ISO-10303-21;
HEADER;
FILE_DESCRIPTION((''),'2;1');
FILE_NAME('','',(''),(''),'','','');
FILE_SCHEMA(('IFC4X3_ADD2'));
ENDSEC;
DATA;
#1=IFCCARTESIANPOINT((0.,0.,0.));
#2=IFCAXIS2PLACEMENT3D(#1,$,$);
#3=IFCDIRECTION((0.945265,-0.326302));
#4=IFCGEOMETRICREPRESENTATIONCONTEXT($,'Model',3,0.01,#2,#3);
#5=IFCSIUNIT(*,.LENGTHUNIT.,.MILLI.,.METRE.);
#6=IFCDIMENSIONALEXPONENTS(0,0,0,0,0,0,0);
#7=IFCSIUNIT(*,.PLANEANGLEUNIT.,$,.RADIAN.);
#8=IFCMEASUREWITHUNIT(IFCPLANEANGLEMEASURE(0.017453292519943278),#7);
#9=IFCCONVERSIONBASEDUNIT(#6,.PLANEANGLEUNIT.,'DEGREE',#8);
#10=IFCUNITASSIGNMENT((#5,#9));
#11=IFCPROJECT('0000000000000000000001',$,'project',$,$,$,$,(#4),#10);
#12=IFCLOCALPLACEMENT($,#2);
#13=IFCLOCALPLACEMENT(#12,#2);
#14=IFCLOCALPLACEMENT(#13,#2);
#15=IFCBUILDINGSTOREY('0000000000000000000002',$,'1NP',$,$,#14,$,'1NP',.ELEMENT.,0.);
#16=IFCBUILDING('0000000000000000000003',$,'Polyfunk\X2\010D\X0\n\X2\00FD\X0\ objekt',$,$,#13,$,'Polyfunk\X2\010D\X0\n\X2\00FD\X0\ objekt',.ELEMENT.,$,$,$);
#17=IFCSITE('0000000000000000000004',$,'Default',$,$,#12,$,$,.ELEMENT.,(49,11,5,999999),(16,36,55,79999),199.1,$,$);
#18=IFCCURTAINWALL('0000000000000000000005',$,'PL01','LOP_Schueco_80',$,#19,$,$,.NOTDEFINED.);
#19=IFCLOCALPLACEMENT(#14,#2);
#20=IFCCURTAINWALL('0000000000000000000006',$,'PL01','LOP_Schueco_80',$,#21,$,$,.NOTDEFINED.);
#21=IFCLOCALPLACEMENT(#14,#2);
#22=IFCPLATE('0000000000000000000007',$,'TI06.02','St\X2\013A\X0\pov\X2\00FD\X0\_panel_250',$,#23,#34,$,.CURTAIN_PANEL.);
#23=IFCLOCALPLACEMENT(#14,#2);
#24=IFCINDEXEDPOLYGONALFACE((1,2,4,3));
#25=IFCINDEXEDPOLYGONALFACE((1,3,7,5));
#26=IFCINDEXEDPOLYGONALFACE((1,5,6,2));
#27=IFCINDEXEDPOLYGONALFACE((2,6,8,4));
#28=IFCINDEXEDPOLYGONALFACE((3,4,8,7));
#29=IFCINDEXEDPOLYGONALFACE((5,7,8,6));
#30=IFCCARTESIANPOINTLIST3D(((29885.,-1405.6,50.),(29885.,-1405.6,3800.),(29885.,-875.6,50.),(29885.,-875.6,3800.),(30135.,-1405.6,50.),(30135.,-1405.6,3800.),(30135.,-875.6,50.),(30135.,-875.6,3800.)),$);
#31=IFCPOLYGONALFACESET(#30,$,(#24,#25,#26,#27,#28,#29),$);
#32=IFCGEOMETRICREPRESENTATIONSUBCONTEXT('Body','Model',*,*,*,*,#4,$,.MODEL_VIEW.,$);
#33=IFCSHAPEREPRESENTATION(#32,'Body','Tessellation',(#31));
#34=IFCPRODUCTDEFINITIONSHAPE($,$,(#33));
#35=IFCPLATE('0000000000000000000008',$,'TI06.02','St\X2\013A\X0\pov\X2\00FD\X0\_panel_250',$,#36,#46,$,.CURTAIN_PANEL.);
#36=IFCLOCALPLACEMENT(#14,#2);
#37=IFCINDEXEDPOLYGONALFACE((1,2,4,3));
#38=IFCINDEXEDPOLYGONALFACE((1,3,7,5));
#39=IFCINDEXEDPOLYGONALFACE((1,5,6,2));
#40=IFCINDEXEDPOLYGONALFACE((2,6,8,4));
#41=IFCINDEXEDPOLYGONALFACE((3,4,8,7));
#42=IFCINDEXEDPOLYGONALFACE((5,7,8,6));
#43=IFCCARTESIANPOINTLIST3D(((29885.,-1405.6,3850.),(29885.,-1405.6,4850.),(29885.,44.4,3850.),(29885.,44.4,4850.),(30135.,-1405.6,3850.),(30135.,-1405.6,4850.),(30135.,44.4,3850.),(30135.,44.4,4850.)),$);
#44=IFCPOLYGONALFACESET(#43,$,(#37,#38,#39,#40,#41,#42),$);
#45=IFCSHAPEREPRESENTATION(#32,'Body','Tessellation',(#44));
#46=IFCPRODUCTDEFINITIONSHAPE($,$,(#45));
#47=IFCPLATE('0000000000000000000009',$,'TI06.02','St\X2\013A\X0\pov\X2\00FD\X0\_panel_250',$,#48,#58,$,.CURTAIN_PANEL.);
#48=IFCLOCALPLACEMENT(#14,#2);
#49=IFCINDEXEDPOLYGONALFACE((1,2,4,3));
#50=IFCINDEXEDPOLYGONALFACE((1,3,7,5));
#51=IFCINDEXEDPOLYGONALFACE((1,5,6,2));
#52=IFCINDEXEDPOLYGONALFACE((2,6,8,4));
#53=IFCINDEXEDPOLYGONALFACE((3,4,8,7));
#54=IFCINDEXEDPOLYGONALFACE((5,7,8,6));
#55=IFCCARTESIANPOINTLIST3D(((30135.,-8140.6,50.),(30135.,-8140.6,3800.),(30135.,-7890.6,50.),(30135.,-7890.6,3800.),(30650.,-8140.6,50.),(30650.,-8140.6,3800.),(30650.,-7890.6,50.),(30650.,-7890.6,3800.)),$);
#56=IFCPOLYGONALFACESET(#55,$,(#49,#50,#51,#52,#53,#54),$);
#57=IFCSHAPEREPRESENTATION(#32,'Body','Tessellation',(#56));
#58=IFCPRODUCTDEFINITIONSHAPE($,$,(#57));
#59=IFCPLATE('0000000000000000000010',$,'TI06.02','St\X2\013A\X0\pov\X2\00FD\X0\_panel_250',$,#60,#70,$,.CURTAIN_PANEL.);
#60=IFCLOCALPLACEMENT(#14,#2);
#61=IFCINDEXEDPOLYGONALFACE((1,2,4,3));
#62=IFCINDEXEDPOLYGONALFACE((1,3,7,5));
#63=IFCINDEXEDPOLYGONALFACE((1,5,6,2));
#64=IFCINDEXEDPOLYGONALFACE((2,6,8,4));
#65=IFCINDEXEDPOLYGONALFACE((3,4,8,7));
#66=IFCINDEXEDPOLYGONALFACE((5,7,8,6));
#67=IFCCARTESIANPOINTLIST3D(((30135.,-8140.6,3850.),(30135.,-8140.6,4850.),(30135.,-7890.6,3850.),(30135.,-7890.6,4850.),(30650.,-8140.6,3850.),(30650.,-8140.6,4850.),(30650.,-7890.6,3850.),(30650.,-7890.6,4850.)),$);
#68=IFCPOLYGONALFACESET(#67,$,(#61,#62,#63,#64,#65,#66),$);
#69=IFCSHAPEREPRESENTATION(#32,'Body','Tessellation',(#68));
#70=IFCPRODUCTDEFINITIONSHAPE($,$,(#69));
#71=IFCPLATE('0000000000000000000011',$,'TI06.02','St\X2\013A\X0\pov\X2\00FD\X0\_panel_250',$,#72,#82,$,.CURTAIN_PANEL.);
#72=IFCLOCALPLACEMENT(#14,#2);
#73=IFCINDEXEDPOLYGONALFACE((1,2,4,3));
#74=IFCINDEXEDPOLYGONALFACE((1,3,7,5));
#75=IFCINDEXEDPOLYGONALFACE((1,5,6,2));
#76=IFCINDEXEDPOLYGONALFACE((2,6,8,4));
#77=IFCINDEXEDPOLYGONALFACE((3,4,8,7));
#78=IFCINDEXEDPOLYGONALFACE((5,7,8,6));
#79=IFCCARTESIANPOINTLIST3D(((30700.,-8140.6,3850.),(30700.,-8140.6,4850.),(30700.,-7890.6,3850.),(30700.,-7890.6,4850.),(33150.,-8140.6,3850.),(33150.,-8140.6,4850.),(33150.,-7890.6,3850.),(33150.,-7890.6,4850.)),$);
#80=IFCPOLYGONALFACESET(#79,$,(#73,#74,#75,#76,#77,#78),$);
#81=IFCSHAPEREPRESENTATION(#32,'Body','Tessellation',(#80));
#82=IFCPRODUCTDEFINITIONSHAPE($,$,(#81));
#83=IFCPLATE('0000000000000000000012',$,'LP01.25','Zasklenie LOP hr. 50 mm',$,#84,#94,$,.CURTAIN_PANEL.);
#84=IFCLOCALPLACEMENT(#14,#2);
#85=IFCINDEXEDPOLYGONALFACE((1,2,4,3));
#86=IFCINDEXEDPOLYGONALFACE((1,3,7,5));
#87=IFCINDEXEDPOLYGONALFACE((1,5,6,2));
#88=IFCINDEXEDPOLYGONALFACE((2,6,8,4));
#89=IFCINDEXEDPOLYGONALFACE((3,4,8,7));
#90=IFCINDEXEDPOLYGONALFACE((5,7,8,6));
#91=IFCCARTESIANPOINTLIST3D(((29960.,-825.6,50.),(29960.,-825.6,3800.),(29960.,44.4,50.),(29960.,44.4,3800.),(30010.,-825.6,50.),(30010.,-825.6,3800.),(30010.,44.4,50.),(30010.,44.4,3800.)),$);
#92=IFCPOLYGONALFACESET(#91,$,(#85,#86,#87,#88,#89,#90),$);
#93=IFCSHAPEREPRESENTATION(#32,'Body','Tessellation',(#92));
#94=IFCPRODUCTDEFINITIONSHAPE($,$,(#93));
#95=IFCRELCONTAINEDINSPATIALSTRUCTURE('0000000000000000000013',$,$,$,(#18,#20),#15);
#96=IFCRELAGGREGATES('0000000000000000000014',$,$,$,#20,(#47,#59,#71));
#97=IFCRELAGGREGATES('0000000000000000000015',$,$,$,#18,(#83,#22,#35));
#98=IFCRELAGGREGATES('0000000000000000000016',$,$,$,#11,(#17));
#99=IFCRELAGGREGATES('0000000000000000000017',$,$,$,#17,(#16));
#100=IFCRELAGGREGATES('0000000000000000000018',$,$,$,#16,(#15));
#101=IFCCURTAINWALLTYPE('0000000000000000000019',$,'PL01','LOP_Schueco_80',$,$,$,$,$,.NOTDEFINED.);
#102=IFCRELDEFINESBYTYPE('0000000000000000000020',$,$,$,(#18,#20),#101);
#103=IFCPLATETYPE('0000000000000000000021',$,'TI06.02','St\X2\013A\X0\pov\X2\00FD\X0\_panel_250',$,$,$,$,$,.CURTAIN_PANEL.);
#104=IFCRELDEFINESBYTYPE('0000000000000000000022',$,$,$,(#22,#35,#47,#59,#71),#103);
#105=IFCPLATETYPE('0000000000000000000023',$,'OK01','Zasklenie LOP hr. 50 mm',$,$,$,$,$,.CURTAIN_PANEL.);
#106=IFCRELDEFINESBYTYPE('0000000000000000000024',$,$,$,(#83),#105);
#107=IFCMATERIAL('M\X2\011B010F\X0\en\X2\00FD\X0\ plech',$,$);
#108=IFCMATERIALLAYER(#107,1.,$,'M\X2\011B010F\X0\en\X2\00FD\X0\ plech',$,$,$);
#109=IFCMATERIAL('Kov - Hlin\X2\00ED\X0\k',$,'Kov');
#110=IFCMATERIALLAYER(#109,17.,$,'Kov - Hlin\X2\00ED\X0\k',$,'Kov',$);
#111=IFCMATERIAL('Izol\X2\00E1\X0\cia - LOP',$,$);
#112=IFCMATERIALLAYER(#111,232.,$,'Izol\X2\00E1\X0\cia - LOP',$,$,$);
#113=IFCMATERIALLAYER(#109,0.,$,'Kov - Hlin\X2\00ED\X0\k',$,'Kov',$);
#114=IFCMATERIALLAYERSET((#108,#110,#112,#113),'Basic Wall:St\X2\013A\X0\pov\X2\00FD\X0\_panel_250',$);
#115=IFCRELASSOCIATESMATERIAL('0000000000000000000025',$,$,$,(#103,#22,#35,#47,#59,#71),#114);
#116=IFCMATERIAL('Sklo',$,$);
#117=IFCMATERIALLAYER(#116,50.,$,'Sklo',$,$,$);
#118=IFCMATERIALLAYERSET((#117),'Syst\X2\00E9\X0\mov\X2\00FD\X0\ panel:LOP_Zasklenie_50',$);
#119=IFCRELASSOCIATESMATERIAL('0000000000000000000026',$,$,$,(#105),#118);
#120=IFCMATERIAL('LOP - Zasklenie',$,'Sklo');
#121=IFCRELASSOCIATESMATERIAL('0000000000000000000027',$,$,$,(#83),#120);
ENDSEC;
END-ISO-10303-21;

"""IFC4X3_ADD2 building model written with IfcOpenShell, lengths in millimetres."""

from ifc_helpers import new_model, entity, si_unit, converted_unit, direction, frame, frame_2d, origin, place, context, subcontext, project, spatial, rectangle, extrude, source, transform, mapped, material, layer, layer_set, layer_usage, type_object, type_shapes, element, aggregate, save


model = new_model("IFC4X3_ADD2")

# Units and contexts
model_context = context("Model", 3, precision=0.01, world=origin(), true_north=direction((0.945265, -0.326302)))
body_context = subcontext(model_context, "Body", "Model", "MODEL_VIEW")
ifc_project = project(units=[si_unit("LENGTHUNIT", "METRE", prefix="MILLI"), converted_unit("PLANEANGLEUNIT", "DEGREE", entity("IfcPlaneAngleMeasure", 0.017453292519943278), si_unit("PLANEANGLEUNIT", "RADIAN"), dimensions=[0, 0, 0, 0, 0, 0, 0])], contexts=[model_context])

# Site, building, storey
site_placement = place(None, origin())
site = spatial("IfcSite", under=ifc_project, at=site_placement, Name="Default", CompositionType="ELEMENT", RefLatitude=(49, 11, 5, 999999), RefLongitude=(16, 36, 55, 79999), RefElevation=199.1)
building_placement = place(site_placement, origin())
building = spatial("IfcBuilding", under=site, at=building_placement, Name="Polyfunkčný objekt", LongName="Polyfunkčný objekt", CompositionType="ELEMENT")
storey_placement = place(building_placement, origin())
storey = spatial("IfcBuildingStorey", under=building, at=storey_placement, Name="1NP", LongName="1NP", CompositionType="ELEMENT", Elevation=0.0)

# Curtain wall
curtain_wall_type = type_object("IfcCurtainWallType", Name="PL01", Description="LOP_Schueco_80", PredefinedType="NOTDEFINED")
curtain_wall_1_placement = place(storey_placement, origin())
curtain_wall_1 = element("IfcCurtainWall", 1, at=curtain_wall_1_placement, inside=storey, type_object=curtain_wall_type, Name="PL01", Description="LOP_Schueco_80", PredefinedType="NOTDEFINED")

# Curtain wall
curtain_wall_2_placement = place(storey_placement, origin())
curtain_wall_2 = element("IfcCurtainWall", 2, at=curtain_wall_2_placement, inside=storey, type_object=curtain_wall_type, Name="PL01", Description="LOP_Schueco_80", PredefinedType="NOTDEFINED")

# Plates
ifc_material_1 = material(Name="Měďený plech")
ifc_layer_1 = layer(ifc_material_1, 1.0, Name="Měďený plech")
ifc_material_2 = material(Name="Kov - Hliník", Category="Kov")
ifc_layer_2 = layer(ifc_material_2, 17.0, Name="Kov - Hliník", Category="Kov")
ifc_material_3 = material(Name="Izolácia - LOP")
ifc_layer_3 = layer(ifc_material_3, 232.0, Name="Izolácia - LOP")
ifc_layer_4 = layer(ifc_material_2, 0.0, Name="Kov - Hliník", Category="Kov")
ifc_layer_set_1 = layer_set([ifc_layer_1, ifc_layer_2, ifc_layer_3, ifc_layer_4], Name="Basic Wall:Stĺpový_panel_250")
ifc_layer_usage_1 = layer_usage(ifc_layer_set_1, "AXIS2", "POSITIVE", -125.0)
plate_type_1 = type_object("IfcPlateType", Name="TI06.02", Description="Stĺpový_panel_250", PredefinedType="CURTAIN_PANEL", material=ifc_layer_set_1)
plate_1_placement = place(storey_placement, frame((30010.0, -875.6, 50.0), z_axis=(0.0, 0.0, 1.0), x_axis=(0.0, -1.0, 0.0)))
plate_1 = element("IfcPlate", 3, at=plate_1_placement, type_object=plate_type_1, material=ifc_layer_usage_1, Name="TI06.02", Description="Stĺpový_panel_250", PredefinedType="CURTAIN_PANEL", context=body_context, shape_type="SweptSolid", body=[
    extrude(rectangle(XDim=250.0, YDim=530.0, at=frame_2d((0.0, 0.0), x_axis=(1.0, 0.0))), frame((265.0, 0.0, 0.0), z_axis=(0.0, 0.0, 1.0), x_axis=(0.0, 1.0, 0.0)), (0.0, 0.0, 1.0), 3750.0),
])
ifc_layer_usage_2 = layer_usage(ifc_layer_set_1, "AXIS2", "POSITIVE", -125.0)
plate_2_placement = place(storey_placement, frame((30010.0, 44.4, 3850.0), z_axis=(0.0, 0.0, 1.0), x_axis=(0.0, -1.0, 0.0)))
plate_2 = element("IfcPlate", 4, at=plate_2_placement, type_object=plate_type_1, material=ifc_layer_usage_2, Name="TI06.02", Description="Stĺpový_panel_250", PredefinedType="CURTAIN_PANEL", context=body_context, shape_type="SweptSolid", body=[
    extrude(rectangle(XDim=250.0, YDim=1450.0, at=frame_2d((0.0, 0.0), x_axis=(1.0, 0.0))), frame((725.0, 0.0, 0.0), z_axis=(0.0, 0.0, 1.0), x_axis=(0.0, 1.0, 0.0)), (0.0, 0.0, 1.0), 1000.0),
])
ifc_layer_usage_3 = layer_usage(ifc_layer_set_1, "AXIS2", "POSITIVE", -125.0)
plate_3_placement = place(storey_placement, frame((30135.0, -8015.6, 50.0)))
plate_3 = element("IfcPlate", 5, at=plate_3_placement, type_object=plate_type_1, material=ifc_layer_usage_3, Name="TI06.02", Description="Stĺpový_panel_250", PredefinedType="CURTAIN_PANEL", context=body_context, shape_type="SweptSolid", body=[
    extrude(rectangle(XDim=250.0, YDim=515.0, at=frame_2d((0.0, 0.0), x_axis=(1.0, 0.0))), frame((257.5, 0.0, 0.0), z_axis=(0.0, 0.0, 1.0), x_axis=(0.0, 1.0, 0.0)), (0.0, 0.0, 1.0), 3750.0),
])
ifc_layer_usage_4 = layer_usage(ifc_layer_set_1, "AXIS2", "POSITIVE", -125.0)
plate_4_placement = place(storey_placement, frame((30135.0, -8015.6, 3850.0)))
plate_4 = element("IfcPlate", 6, at=plate_4_placement, type_object=plate_type_1, material=ifc_layer_usage_4, Name="TI06.02", Description="Stĺpový_panel_250", PredefinedType="CURTAIN_PANEL", context=body_context, shape_type="SweptSolid", body=[
    extrude(rectangle(XDim=250.0, YDim=515.0, at=frame_2d((0.0, 0.0), x_axis=(1.0, 0.0))), frame((257.5, 0.0, 0.0), z_axis=(0.0, 0.0, 1.0), x_axis=(0.0, 1.0, 0.0)), (0.0, 0.0, 1.0), 1000.0),
])
ifc_layer_usage_5 = layer_usage(ifc_layer_set_1, "AXIS2", "POSITIVE", -125.0)
plate_5_placement = place(storey_placement, frame((30700.0, -8015.6, 3850.0)))
plate_5 = element("IfcPlate", 7, at=plate_5_placement, type_object=plate_type_1, material=ifc_layer_usage_5, Name="TI06.02", Description="Stĺpový_panel_250", PredefinedType="CURTAIN_PANEL", context=body_context, shape_type="SweptSolid", body=[
    extrude(rectangle(XDim=250.0, YDim=2450.0, at=frame_2d((0.0, 0.0), x_axis=(1.0, 0.0))), frame((1225.0, 0.0, 0.0), z_axis=(0.0, 0.0, 1.0), x_axis=(0.0, 1.0, 0.0)), (0.0, 0.0, 1.0), 1000.0),
])
aggregate(curtain_wall_2, [plate_3, plate_4, plate_5])
ifc_material_4 = material(Name="LOP - Zasklenie", Category="Sklo")
ifc_material_5 = material(Name="Sklo")
ifc_layer_5 = layer(ifc_material_5, 50.0, Name="Sklo")
ifc_layer_set_2 = layer_set([ifc_layer_5], Name="Systémový panel:LOP_Zasklenie_50")
plate_type_2 = type_object("IfcPlateType", Name="OK01", Description="Zasklenie LOP hr. 50 mm", PredefinedType="CURTAIN_PANEL", material=ifc_layer_set_2)
shared_shape_1 = source(origin(), body_context, "Body", "SweptSolid", [
    extrude(rectangle(XDim=3750.0, YDim=870.0, at=frame_2d((-141.7, 0.0), x_axis=(1.0, 0.0))), frame((0.0, -50.0, 2016.7), z_axis=(0.0, 1.0, 0.0), x_axis=(0.0, 0.0, 1.0)), (0.0, 0.0, 1.0), 50.0),
])
type_shapes(plate_type_2, [shared_shape_1])
plate_6_placement = place(curtain_wall_1_placement, frame((30010.0, -390.6, 50.0), z_axis=(0.0, 0.0, 1.0), x_axis=(0.0, -1.0, 0.0)))
plate_6 = element("IfcPlate", 8, at=plate_6_placement, type_object=plate_type_2, material=ifc_material_4, Name="LP01.25", Description="Zasklenie LOP hr. 50 mm", PredefinedType="CURTAIN_PANEL", context=body_context, shape_type="MappedRepresentation", body=[
    mapped(shared_shape_1, transform((0.0, 0.0, 0.0), scale=1.0)),
])
aggregate(curtain_wall_1, [plate_6, plate_1, plate_2])

save(model, "model.ifc")
